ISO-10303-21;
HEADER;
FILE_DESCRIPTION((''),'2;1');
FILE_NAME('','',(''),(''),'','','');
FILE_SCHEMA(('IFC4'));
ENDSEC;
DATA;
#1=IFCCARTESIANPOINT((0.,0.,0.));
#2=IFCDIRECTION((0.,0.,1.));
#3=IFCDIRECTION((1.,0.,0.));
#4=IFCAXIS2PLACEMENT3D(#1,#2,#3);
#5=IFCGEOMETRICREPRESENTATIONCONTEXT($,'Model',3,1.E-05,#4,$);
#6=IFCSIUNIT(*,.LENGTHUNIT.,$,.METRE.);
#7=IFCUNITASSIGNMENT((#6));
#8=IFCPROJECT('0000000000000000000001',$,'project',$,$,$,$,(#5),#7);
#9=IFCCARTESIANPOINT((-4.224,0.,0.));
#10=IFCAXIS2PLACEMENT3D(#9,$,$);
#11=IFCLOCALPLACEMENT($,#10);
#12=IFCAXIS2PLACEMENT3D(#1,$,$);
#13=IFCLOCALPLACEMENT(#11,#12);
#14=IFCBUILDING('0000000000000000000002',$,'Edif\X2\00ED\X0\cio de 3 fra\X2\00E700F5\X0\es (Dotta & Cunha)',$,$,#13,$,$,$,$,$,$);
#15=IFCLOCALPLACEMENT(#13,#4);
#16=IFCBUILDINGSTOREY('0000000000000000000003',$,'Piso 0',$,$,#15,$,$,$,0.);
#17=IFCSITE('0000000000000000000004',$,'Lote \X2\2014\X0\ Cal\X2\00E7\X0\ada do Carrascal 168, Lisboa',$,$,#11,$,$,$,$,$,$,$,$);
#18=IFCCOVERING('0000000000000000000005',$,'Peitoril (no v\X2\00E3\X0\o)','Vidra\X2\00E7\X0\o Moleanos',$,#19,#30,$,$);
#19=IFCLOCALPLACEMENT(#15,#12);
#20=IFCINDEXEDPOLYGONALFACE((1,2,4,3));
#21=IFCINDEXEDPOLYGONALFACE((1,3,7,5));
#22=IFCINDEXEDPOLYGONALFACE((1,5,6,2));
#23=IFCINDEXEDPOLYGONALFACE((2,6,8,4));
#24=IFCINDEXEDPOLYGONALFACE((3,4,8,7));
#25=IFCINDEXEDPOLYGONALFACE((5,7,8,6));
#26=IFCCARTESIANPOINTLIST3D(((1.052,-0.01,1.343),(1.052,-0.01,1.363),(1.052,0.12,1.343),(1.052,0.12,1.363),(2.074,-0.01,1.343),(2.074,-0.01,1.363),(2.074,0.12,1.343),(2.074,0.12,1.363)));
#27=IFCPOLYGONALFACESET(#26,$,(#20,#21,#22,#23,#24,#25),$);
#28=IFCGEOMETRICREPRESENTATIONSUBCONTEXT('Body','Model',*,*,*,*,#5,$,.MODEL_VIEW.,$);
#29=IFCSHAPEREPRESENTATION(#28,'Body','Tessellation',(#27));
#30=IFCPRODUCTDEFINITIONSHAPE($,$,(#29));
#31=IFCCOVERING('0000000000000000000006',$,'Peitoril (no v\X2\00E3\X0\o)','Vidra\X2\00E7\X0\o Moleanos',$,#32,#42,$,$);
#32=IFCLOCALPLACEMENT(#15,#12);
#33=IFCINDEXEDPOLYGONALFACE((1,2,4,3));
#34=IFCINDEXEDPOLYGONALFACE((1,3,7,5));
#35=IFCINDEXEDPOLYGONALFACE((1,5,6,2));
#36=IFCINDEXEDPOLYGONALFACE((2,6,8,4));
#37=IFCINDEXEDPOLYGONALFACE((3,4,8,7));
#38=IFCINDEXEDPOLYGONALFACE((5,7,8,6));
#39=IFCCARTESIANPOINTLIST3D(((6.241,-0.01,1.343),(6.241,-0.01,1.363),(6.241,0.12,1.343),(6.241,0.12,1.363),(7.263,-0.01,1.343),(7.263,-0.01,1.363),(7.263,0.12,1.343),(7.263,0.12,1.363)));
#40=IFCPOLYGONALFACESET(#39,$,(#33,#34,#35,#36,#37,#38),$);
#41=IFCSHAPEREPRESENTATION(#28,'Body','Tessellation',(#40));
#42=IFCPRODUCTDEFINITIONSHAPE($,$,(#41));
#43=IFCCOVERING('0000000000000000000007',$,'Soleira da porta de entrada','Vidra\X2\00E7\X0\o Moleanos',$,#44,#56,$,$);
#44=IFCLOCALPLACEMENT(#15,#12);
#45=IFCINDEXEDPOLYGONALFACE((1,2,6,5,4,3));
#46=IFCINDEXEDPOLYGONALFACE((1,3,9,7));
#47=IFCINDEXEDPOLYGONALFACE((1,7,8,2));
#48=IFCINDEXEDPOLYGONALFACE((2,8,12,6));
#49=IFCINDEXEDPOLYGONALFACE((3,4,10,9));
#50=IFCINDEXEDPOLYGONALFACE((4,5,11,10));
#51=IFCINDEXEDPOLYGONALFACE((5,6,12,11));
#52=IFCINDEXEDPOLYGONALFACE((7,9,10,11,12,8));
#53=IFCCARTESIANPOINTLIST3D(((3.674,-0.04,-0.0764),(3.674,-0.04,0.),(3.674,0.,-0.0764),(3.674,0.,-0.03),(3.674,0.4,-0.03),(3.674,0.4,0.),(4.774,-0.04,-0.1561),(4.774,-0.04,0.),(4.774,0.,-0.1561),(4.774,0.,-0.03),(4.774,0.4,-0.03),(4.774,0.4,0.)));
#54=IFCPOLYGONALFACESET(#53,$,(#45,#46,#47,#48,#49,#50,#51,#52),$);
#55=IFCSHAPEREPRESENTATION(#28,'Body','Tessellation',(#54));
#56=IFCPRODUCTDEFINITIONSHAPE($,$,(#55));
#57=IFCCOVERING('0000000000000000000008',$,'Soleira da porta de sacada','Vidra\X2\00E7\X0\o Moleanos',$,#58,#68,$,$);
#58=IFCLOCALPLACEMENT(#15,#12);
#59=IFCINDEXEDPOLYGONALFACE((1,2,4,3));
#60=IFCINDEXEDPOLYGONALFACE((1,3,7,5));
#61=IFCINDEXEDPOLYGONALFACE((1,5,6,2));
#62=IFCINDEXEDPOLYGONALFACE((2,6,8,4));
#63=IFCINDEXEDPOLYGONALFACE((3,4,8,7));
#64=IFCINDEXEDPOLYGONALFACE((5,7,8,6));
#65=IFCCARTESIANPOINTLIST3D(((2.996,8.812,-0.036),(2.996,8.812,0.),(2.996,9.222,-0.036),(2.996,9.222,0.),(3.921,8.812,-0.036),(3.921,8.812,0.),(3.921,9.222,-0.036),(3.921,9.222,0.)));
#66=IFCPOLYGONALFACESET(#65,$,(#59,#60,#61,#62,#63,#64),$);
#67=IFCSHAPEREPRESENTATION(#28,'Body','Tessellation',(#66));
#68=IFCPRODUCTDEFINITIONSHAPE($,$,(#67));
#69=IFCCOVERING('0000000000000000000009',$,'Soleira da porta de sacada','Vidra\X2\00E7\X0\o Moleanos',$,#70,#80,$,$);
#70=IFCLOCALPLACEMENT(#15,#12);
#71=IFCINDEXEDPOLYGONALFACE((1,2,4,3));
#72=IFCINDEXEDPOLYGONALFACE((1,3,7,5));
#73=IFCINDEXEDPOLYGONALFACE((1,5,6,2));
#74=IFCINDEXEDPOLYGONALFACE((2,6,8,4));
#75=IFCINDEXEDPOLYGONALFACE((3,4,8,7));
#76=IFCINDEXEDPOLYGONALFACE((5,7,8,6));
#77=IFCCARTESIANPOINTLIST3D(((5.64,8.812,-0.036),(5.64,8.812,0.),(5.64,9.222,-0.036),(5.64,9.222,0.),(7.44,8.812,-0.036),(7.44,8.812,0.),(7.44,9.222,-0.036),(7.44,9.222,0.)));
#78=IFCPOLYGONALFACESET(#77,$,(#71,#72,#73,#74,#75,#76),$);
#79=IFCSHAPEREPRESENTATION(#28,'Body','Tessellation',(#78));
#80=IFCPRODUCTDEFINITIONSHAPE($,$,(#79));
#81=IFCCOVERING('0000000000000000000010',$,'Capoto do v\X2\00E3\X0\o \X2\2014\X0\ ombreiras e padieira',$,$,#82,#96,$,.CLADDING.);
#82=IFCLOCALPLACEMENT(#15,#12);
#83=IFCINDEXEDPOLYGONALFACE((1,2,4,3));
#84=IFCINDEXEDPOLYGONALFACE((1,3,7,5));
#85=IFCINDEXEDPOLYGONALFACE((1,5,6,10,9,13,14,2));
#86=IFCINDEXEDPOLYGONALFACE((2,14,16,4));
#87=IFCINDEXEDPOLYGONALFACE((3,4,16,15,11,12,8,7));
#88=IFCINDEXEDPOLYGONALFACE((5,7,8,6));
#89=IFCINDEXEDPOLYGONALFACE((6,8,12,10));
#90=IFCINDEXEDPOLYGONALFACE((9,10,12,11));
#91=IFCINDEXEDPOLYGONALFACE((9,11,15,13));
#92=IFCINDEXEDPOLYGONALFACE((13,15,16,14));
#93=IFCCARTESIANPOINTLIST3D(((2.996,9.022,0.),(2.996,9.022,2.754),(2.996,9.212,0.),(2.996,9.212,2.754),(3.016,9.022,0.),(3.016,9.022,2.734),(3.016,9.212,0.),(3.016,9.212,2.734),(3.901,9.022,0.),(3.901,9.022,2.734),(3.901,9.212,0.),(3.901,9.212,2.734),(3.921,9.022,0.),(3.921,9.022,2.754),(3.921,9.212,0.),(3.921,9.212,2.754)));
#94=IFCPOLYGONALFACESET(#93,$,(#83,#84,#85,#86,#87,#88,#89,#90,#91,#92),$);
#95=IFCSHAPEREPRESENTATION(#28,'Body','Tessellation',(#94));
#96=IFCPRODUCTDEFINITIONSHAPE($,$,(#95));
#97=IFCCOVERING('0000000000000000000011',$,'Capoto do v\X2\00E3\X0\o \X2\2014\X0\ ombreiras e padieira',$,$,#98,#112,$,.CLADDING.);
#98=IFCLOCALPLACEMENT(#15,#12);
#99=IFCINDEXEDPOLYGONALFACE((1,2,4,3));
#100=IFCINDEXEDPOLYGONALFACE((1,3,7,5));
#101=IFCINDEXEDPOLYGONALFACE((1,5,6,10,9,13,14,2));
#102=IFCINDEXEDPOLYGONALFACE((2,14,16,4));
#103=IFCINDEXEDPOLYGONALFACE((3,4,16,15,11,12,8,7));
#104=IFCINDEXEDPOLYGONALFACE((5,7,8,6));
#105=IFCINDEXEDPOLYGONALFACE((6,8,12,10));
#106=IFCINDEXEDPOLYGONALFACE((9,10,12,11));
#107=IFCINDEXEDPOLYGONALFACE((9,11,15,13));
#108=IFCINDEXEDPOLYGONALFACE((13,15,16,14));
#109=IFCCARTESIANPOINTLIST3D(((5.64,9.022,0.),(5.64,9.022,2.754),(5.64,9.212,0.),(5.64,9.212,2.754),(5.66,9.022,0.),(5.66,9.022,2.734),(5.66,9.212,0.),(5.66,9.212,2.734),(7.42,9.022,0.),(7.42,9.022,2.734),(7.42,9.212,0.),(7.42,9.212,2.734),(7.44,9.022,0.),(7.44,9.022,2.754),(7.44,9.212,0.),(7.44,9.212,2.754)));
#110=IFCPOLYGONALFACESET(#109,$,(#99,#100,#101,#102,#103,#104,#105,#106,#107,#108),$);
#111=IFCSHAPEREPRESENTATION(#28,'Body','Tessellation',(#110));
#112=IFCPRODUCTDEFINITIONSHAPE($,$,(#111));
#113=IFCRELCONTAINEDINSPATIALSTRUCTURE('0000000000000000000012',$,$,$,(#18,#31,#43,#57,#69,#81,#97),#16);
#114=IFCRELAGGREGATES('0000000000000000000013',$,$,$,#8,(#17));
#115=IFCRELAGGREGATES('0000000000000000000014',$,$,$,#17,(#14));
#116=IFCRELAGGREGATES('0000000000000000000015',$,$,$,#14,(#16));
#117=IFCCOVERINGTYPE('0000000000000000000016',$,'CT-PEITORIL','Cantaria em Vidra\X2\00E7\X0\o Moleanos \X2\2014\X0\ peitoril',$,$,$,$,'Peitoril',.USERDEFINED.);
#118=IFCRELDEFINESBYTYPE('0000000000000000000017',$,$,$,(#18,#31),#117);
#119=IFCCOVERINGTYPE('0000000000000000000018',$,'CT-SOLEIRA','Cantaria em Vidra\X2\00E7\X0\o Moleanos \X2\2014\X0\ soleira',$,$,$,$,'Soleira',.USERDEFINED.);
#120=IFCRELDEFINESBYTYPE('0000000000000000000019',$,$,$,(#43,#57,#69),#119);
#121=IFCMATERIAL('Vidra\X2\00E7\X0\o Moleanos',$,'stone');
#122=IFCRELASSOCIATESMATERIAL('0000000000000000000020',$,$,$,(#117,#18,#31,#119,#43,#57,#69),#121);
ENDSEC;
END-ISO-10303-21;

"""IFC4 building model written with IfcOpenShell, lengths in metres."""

from ifc_helpers import new_model, si_unit, frame, origin, origin_with_axes, place, context, subcontext, project, spatial, line, indexed_curve, outline, extrude, clip, halfspace, material, type_object, element, save


model = new_model("IFC4")

# Units and contexts
model_context = context("Model", 3, precision=1e-05, world=origin_with_axes())
body_context = subcontext(model_context, "Body", "Model", "MODEL_VIEW")
ifc_project = project(units=[si_unit("LENGTHUNIT", "METRE")], contexts=[model_context])

# Site, building, storey
site_placement = place(None, frame((-4.224, 0.0, 0.0)))
site = spatial("IfcSite", under=ifc_project, at=site_placement, Name="Lote — Calçada do Carrascal 168, Lisboa")
building_placement = place(site_placement, origin())
building = spatial("IfcBuilding", under=site, at=building_placement, Name="Edifício de 3 frações (Dotta & Cunha)")
storey_placement = place(building_placement, origin_with_axes())
storey = spatial("IfcBuildingStorey", under=building, at=storey_placement, Name="Piso 0", Elevation=0.0)

# Coverings
ifc_material_1 = material(Name="Vidraço Moleanos", Category="stone")
covering_type_1 = type_object("IfcCoveringType", Name="CT-PEITORIL", Description="Cantaria em Vidraço Moleanos — peitoril", ElementType="Peitoril", PredefinedType="USERDEFINED", material=ifc_material_1)
covering_1_placement = place(storey_placement, frame((0.0, 0.12, 0.0), z_axis=(0.0, -1.0, 0.0), x_axis=(1.0, 0.0, 0.0)))
element("IfcCovering", 1, at=covering_1_placement, inside=storey, type_object=covering_type_1, material=ifc_material_1, Name="Peitoril (no vão)", Description="Vidraço Moleanos", context=body_context, shape_type="SweptSolid", body=[
    extrude(outline(indexed_curve([(2.074, 1.343), (2.074, 1.363), (1.052, 1.363), (1.052, 1.343)], segments=[line(1, 2, 3, 4, 1)])), origin_with_axes(), (0.0, 0.0, 1.0), 0.13),
])
covering_2_placement = place(storey_placement, frame((0.0, 0.12, 0.0), z_axis=(0.0, -1.0, 0.0), x_axis=(1.0, 0.0, 0.0)))
element("IfcCovering", 2, at=covering_2_placement, inside=storey, type_object=covering_type_1, material=ifc_material_1, Name="Peitoril (no vão)", Description="Vidraço Moleanos", context=body_context, shape_type="SweptSolid", body=[
    extrude(outline(indexed_curve([(7.263, 1.343), (7.263, 1.363), (6.241, 1.363), (6.241, 1.343)], segments=[line(1, 2, 3, 4, 1)])), origin_with_axes(), (0.0, 0.0, 1.0), 0.13),
])
covering_type_2 = type_object("IfcCoveringType", Name="CT-SOLEIRA", Description="Cantaria em Vidraço Moleanos — soleira", ElementType="Soleira", PredefinedType="USERDEFINED", material=ifc_material_1)
covering_3_placement = place(storey_placement, frame((3.674, 0.0, 0.0), z_axis=(1.0, 0.0, 0.0), x_axis=(0.0, 1.0, 0.0)))
element("IfcCovering", 3, at=covering_3_placement, inside=storey, type_object=covering_type_2, material=ifc_material_1, Name="Soleira da porta de entrada", Description="Vidraço Moleanos", context=body_context, shape_type="Clipping", body=[
    clip(extrude(outline(indexed_curve([(-0.04, -0.1561), (0.0, -0.1561), (0.0, -0.03), (0.4, -0.03), (0.4, 0.0), (-0.04, 0.0)], segments=[line(1, 2, 3, 4, 5, 6, 1)])), origin_with_axes(), (0.0, 0.0, 1.0), 1.1), halfspace(frame((0.0, -0.0764, 0.0), z_axis=(0.0, -0.997382, -0.07231), x_axis=(1.0, 0.0, 0.0)), False)),
])
covering_4_placement = place(storey_placement, frame((0.0, 0.0, -0.036), z_axis=(0.0, 0.0, 1.0), x_axis=(1.0, 0.0, 0.0)))
element("IfcCovering", 4, at=covering_4_placement, inside=storey, type_object=covering_type_2, material=ifc_material_1, Name="Soleira da porta de sacada", Description="Vidraço Moleanos", context=body_context, shape_type="SweptSolid", body=[
    extrude(outline(indexed_curve([(3.921, 8.812), (3.921, 9.222), (2.996, 9.222), (2.996, 8.812)], segments=[line(1, 2, 3, 4, 1)])), origin_with_axes(), (0.0, 0.0, 1.0), 0.036),
])
covering_5_placement = place(storey_placement, frame((0.0, 0.0, -0.036), z_axis=(0.0, 0.0, 1.0), x_axis=(1.0, 0.0, 0.0)))
element("IfcCovering", 5, at=covering_5_placement, inside=storey, type_object=covering_type_2, material=ifc_material_1, Name="Soleira da porta de sacada", Description="Vidraço Moleanos", context=body_context, shape_type="SweptSolid", body=[
    extrude(outline(indexed_curve([(7.44, 8.812), (7.44, 9.222), (5.64, 9.222), (5.64, 8.812)], segments=[line(1, 2, 3, 4, 1)])), origin_with_axes(), (0.0, 0.0, 1.0), 0.036),
])
covering_6_placement = place(storey_placement, frame((0.0, 9.212, 0.0), z_axis=(0.0, -1.0, 0.0), x_axis=(1.0, 0.0, 0.0)))
element("IfcCovering", 6, at=covering_6_placement, inside=storey, Name="Capoto do vão — ombreiras e padieira", PredefinedType="CLADDING", context=body_context, shape_type="SweptSolid", body=[
    extrude(outline(indexed_curve([(2.996, 0.0), (2.996, 2.754), (3.921, 2.754), (3.921, 0.0), (3.901, 0.0), (3.901, 2.734), (3.016, 2.734), (3.016, 0.0)], segments=[line(1, 2, 3, 4, 5, 6, 7, 8, 1)])), origin_with_axes(), (0.0, 0.0, 1.0), 0.19),
])
covering_7_placement = place(storey_placement, frame((0.0, 9.212, 0.0), z_axis=(0.0, -1.0, 0.0), x_axis=(1.0, 0.0, 0.0)))
element("IfcCovering", 7, at=covering_7_placement, inside=storey, Name="Capoto do vão — ombreiras e padieira", PredefinedType="CLADDING", context=body_context, shape_type="SweptSolid", body=[
    extrude(outline(indexed_curve([(5.64, 0.0), (5.64, 2.754), (7.44, 2.754), (7.44, 0.0), (7.42, 0.0), (7.42, 2.734), (5.66, 2.734), (5.66, 0.0)], segments=[line(1, 2, 3, 4, 5, 6, 7, 8, 1)])), origin_with_axes(), (0.0, 0.0, 1.0), 0.19),
])

save(model, "model.ifc")
